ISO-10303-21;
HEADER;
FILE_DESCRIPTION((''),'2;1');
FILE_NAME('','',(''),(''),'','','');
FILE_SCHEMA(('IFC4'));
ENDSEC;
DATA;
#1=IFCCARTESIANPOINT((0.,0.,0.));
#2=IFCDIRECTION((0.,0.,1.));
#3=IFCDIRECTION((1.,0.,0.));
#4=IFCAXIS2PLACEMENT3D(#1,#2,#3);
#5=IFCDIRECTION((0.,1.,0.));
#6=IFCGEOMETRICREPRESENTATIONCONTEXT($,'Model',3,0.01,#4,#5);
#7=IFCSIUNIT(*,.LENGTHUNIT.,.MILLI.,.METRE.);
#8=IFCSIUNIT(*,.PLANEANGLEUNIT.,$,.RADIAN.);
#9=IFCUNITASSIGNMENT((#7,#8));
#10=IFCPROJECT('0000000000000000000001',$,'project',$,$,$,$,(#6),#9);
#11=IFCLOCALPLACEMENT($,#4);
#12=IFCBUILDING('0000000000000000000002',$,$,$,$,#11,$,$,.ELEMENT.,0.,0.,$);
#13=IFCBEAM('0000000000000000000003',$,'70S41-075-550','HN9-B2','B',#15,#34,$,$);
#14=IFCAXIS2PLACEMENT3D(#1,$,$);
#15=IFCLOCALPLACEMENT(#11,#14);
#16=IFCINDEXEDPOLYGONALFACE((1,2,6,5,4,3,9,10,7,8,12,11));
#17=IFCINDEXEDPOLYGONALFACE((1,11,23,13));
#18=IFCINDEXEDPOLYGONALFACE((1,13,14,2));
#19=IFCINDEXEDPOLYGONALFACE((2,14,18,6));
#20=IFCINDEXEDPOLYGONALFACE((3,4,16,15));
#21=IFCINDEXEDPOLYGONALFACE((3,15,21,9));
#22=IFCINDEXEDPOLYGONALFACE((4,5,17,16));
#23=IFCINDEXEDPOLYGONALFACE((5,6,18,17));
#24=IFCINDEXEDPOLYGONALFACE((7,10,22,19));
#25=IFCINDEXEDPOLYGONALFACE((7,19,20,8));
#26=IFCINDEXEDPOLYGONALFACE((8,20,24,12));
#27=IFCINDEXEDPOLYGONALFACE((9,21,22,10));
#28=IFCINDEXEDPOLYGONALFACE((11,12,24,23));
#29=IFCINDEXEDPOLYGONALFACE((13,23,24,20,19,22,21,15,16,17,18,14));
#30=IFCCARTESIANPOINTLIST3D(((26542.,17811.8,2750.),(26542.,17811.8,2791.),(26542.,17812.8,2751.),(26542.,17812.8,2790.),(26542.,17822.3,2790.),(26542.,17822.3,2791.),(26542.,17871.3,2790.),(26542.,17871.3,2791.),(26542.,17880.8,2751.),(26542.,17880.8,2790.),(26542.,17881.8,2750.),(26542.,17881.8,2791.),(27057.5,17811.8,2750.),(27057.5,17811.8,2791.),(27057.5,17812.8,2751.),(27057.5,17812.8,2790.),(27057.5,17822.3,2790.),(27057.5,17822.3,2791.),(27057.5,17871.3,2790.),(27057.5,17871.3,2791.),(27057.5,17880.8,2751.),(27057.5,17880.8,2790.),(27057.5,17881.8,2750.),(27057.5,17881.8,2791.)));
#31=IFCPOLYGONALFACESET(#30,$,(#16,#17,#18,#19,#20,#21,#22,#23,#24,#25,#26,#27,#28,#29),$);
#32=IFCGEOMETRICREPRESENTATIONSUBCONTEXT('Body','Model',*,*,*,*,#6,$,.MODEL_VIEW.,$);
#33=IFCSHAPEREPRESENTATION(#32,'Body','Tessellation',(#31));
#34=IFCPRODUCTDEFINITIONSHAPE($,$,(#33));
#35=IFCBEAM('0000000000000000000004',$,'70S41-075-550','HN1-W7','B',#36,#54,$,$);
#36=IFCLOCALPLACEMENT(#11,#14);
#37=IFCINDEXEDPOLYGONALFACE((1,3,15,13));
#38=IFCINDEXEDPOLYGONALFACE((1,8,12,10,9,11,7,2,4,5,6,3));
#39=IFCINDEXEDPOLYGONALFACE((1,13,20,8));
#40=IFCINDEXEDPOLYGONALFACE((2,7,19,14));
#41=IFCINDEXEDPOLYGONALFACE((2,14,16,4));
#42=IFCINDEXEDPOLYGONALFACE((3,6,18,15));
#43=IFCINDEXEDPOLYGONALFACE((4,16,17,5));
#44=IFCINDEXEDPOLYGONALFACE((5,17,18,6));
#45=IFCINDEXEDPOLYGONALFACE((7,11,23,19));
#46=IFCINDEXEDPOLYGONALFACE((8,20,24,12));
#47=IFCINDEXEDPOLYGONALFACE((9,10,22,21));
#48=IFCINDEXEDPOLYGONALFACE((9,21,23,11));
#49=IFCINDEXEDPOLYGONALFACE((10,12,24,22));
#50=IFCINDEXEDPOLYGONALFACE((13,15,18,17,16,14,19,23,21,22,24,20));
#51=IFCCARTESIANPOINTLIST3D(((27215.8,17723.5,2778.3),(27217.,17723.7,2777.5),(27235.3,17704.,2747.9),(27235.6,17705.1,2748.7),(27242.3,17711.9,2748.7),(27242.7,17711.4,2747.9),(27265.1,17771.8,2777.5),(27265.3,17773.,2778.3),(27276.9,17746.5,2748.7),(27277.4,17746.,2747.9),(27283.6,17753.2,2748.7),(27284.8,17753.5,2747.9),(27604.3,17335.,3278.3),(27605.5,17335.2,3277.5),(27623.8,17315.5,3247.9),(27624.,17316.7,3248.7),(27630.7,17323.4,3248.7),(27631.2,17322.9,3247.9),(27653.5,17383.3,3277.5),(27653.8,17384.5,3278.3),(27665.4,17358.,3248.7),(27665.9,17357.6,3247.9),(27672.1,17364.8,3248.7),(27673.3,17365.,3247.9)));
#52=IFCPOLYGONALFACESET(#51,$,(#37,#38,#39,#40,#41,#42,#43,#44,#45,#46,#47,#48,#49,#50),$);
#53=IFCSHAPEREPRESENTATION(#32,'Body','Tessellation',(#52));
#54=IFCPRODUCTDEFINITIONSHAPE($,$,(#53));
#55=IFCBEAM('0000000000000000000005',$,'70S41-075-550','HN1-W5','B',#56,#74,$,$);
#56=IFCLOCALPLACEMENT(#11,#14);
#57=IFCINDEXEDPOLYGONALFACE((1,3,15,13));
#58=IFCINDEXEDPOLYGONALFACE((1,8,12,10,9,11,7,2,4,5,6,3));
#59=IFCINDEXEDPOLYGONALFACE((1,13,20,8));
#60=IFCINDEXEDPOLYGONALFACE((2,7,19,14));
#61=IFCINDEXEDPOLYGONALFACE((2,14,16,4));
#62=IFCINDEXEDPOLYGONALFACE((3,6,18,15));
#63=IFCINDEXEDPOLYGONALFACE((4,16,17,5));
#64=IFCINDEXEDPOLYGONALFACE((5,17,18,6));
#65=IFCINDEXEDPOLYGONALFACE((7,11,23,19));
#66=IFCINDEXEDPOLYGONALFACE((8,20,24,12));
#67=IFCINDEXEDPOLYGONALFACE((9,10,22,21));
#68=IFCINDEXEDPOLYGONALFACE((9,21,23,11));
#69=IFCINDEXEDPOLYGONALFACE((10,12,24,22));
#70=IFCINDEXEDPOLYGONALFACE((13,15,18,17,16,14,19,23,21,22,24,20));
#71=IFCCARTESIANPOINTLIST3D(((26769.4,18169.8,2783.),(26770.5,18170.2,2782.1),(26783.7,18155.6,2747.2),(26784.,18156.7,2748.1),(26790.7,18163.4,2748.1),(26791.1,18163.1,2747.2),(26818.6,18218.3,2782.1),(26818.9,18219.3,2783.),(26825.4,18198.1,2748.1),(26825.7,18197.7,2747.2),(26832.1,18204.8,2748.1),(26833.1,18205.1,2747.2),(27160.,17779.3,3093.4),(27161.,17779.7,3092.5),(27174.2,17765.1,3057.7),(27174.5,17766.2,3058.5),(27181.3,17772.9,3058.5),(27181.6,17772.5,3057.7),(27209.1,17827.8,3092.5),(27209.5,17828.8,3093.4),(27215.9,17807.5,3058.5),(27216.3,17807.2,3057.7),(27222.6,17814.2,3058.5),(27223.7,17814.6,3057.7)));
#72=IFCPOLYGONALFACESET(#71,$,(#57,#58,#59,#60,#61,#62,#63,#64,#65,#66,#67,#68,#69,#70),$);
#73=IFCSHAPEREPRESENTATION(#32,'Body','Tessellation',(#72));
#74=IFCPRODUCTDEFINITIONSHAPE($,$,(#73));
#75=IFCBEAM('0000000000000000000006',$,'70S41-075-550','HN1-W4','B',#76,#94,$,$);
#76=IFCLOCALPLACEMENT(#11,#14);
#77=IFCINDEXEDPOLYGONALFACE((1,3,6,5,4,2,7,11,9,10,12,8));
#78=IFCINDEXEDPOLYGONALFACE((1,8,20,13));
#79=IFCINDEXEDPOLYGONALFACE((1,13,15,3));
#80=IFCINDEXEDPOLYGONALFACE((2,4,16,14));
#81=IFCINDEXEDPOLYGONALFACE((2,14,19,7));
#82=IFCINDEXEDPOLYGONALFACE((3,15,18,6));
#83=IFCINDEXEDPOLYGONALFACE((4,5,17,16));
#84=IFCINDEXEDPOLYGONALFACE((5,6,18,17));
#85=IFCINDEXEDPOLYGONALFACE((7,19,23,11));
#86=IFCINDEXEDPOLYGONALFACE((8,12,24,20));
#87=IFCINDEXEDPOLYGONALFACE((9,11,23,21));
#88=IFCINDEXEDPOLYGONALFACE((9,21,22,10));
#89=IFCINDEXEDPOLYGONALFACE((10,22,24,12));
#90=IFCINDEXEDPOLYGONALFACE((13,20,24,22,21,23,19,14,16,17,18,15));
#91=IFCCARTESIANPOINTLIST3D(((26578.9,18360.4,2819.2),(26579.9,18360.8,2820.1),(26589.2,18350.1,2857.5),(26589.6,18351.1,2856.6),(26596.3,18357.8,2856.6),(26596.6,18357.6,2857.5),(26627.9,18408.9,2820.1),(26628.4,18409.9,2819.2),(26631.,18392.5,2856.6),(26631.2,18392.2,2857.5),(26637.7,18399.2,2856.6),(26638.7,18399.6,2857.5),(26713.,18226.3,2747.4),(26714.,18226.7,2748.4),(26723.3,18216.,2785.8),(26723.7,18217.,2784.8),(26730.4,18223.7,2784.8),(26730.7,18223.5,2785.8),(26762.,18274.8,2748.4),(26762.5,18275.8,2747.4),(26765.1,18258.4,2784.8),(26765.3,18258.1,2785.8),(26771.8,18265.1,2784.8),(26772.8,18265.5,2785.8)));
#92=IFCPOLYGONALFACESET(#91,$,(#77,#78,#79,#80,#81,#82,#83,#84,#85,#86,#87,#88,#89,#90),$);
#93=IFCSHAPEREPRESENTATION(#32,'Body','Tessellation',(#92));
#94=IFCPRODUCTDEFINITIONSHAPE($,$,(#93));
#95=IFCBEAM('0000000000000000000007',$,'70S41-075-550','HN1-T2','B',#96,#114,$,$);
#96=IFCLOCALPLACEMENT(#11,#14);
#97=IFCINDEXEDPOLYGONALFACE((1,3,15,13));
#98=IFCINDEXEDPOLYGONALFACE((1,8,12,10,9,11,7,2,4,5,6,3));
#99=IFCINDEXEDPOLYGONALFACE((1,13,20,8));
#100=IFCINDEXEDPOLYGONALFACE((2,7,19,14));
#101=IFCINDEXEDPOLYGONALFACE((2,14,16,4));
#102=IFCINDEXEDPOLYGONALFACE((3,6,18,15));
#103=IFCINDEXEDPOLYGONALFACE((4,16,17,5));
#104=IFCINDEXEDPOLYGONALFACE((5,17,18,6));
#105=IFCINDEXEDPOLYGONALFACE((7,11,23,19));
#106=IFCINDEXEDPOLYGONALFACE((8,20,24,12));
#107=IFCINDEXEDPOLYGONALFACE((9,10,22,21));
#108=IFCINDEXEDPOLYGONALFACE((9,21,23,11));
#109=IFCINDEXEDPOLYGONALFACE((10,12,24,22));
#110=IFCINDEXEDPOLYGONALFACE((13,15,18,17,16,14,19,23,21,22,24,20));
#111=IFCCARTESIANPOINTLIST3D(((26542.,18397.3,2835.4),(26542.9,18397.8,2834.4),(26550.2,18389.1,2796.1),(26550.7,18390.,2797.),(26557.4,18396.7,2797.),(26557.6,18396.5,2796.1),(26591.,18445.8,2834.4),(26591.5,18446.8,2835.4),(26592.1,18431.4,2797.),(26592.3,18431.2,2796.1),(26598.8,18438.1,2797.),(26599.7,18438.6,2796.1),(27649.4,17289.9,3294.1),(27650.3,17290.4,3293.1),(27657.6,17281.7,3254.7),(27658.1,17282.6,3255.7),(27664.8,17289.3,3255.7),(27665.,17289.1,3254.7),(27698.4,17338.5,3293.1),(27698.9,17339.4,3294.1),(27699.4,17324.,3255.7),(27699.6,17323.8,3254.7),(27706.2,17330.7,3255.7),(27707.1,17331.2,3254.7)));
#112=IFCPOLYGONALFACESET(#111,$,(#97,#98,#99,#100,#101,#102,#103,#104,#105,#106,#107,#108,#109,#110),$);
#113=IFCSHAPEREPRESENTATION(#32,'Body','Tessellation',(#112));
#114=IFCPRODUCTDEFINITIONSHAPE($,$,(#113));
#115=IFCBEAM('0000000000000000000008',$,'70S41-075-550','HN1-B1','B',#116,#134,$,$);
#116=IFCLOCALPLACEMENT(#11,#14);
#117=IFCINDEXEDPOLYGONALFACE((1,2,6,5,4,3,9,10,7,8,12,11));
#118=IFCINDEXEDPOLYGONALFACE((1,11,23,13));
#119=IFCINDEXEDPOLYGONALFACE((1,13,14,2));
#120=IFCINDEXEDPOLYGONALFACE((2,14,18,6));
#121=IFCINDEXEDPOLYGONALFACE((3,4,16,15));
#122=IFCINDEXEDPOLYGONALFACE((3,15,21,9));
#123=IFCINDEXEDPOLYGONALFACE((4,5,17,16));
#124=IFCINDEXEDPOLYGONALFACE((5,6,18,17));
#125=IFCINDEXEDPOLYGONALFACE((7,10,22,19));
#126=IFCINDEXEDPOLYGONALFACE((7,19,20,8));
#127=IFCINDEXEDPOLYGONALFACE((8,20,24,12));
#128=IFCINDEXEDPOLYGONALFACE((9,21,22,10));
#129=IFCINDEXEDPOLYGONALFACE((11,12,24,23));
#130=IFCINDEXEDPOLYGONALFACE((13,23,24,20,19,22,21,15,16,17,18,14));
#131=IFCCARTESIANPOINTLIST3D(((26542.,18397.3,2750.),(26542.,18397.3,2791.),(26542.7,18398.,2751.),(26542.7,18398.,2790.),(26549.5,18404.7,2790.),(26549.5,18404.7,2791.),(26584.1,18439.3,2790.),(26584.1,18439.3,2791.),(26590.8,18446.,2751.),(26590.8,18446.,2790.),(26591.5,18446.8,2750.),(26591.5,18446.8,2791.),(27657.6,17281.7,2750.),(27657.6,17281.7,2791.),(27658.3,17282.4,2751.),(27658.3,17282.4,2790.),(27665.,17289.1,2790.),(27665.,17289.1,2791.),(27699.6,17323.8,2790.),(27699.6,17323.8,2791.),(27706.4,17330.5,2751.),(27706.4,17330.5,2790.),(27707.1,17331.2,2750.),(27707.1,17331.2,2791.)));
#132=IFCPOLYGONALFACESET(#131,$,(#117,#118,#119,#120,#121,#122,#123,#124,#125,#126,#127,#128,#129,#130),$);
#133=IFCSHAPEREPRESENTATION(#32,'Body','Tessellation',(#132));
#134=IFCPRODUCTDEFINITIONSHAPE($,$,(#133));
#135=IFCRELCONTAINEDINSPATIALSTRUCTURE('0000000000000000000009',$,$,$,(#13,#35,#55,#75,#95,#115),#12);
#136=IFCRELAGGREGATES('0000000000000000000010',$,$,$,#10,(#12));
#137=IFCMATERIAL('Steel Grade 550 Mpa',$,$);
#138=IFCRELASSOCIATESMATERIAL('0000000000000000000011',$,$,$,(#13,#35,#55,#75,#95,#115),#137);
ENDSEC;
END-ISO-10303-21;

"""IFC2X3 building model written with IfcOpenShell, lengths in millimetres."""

from ifc_helpers import new_model, si_unit, direction, frame, origin, origin_with_axes, origin_2d_with_axis, place, context, subcontext, project, spatial, c_section, extrude, source, transform, mapped, material, element, save


model = new_model("IFC2X3")

# Units and contexts
model_context = context("Model", 3, precision=0.01, world=origin_with_axes(), true_north=direction((0.0, 1.0, 0.0)))
body_context = subcontext(model_context, "Body", "Model", "MODEL_VIEW")
ifc_project = project(units=[si_unit("LENGTHUNIT", "METRE", prefix="MILLI"), si_unit("PLANEANGLEUNIT", "RADIAN")], contexts=[model_context])

# Building
building_placement = place(None, origin_with_axes())
building = spatial("IfcBuilding", under=ifc_project, at=building_placement, CompositionType="ELEMENT", ElevationOfRefHeight=0.0, ElevationOfTerrain=0.0)

# Shared definitions
ifc_material = material(Name="Steel Grade 550 Mpa")

# Beams
shared_shape_1 = source(origin(), body_context, "Body", "SweptSolid", [
    extrude(c_section(Depth=70.0, Width=41.0, WallThickness=1.0, Girth=10.5, at=origin_2d_with_axis()), origin_with_axes(), (0.0, 0.0, 1.0), 515.5),
])
beam_1_placement = place(None, frame((26542.0, 17846.8, 2770.5), z_axis=(1.0, 0.0, 0.0), x_axis=(0.0, 0.0, 1.0)))
element("IfcBeam", 1, at=beam_1_placement, inside=building, material=ifc_material, Name="70S41-075-550", Description="HN9-B2", ObjectType="B", context=body_context, shape_type="MappedRepresentation", body=[
    mapped(shared_shape_1, transform((0.0, 0.0, 0.0), scale=1.0)),
])
shared_shape_2 = source(origin(), body_context, "Body", "SweptSolid", [
    extrude(c_section(Depth=70.0, Width=41.0, WallThickness=1.0, Girth=10.5, at=origin_2d_with_axis()), origin_with_axes(), (0.0, 0.0, 1.0), 742.9),
])
beam_2_placement = place(None, frame((27638.8, 17350.0, 3263.1), z_axis=(-0.522949, 0.522949, -0.673089), x_axis=(0.475945, -0.475945, -0.739562)))
element("IfcBeam", 2, at=beam_2_placement, inside=building, material=ifc_material, Name="70S41-075-550", Description="HN1-W7", ObjectType="B", context=body_context, shape_type="MappedRepresentation", body=[
    mapped(shared_shape_2, transform((0.0, 0.0, 0.0), scale=1.0)),
])
shared_shape_3 = source(origin(), body_context, "Body", "SweptSolid", [
    extrude(c_section(Depth=70.0, Width=41.0, WallThickness=1.0, Girth=10.5, at=origin_2d_with_axis()), origin_with_axes(), (0.0, 0.0, 1.0), 633.6),
])
beam_3_placement = place(None, frame((27191.8, 17797.0, 3075.5), z_axis=(-0.616417, 0.616417, -0.48996), x_axis=(0.346454, -0.346454, -0.871745)))
element("IfcBeam", 3, at=beam_3_placement, inside=building, material=ifc_material, Name="70S41-075-550", Description="HN1-W5", ObjectType="B", context=body_context, shape_type="MappedRepresentation", body=[
    mapped(shared_shape_3, transform((0.0, 0.0, 0.0), scale=1.0)),
])
shared_shape_4 = source(origin(), body_context, "Body", "SweptSolid", [
    extrude(c_section(Depth=70.0, Width=41.0, WallThickness=1.0, Girth=10.5, at=origin_2d_with_axis()), origin_with_axes(), (0.0, 0.0, 1.0), 202.8),
])
beam_4_placement = place(None, frame((26608.8, 18380.0, 2838.3), z_axis=(0.661376, -0.661376, -0.353784), x_axis=(0.250163, -0.250163, 0.935327)))
element("IfcBeam", 4, at=beam_4_placement, inside=building, material=ifc_material, Name="70S41-075-550", Description="HN1-W4", ObjectType="B", context=body_context, shape_type="MappedRepresentation", body=[
    mapped(shared_shape_4, transform((0.0, 0.0, 0.0), scale=1.0)),
])
shared_shape_5 = source(origin(), body_context, "Body", "SweptSolid", [
    extrude(c_section(Depth=70.0, Width=41.0, WallThickness=1.0, Girth=10.5, at=origin_2d_with_axis()), origin_with_axes(), (0.0, 0.0, 1.0), 1631.9),
])
beam_5_placement = place(None, frame((27678.2, 17310.5, 3274.4), z_axis=(-0.678598, 0.678598, -0.281085), x_axis=(0.198757, -0.198757, -0.959683)))
element("IfcBeam", 5, at=beam_5_placement, inside=building, material=ifc_material, Name="70S41-075-550", Description="HN1-T2", ObjectType="B", context=body_context, shape_type="MappedRepresentation", body=[
    mapped(shared_shape_5, transform((0.0, 0.0, 0.0), scale=1.0)),
])
shared_shape_6 = source(origin(), body_context, "Body", "SweptSolid", [
    extrude(c_section(Depth=70.0, Width=41.0, WallThickness=1.0, Girth=10.5, at=origin_2d_with_axis()), origin_with_axes(), (0.0, 0.0, 1.0), 1577.6),
])
beam_6_placement = place(None, frame((26566.8, 18422.0, 2770.5), z_axis=(0.707107, -0.707107, 0.0), x_axis=(0.0, 0.0, 1.0)))
element("IfcBeam", 6, at=beam_6_placement, inside=building, material=ifc_material, Name="70S41-075-550", Description="HN1-B1", ObjectType="B", context=body_context, shape_type="MappedRepresentation", body=[
    mapped(shared_shape_6, transform((0.0, 0.0, 0.0), scale=1.0)),
])

save(model, "model.ifc")
